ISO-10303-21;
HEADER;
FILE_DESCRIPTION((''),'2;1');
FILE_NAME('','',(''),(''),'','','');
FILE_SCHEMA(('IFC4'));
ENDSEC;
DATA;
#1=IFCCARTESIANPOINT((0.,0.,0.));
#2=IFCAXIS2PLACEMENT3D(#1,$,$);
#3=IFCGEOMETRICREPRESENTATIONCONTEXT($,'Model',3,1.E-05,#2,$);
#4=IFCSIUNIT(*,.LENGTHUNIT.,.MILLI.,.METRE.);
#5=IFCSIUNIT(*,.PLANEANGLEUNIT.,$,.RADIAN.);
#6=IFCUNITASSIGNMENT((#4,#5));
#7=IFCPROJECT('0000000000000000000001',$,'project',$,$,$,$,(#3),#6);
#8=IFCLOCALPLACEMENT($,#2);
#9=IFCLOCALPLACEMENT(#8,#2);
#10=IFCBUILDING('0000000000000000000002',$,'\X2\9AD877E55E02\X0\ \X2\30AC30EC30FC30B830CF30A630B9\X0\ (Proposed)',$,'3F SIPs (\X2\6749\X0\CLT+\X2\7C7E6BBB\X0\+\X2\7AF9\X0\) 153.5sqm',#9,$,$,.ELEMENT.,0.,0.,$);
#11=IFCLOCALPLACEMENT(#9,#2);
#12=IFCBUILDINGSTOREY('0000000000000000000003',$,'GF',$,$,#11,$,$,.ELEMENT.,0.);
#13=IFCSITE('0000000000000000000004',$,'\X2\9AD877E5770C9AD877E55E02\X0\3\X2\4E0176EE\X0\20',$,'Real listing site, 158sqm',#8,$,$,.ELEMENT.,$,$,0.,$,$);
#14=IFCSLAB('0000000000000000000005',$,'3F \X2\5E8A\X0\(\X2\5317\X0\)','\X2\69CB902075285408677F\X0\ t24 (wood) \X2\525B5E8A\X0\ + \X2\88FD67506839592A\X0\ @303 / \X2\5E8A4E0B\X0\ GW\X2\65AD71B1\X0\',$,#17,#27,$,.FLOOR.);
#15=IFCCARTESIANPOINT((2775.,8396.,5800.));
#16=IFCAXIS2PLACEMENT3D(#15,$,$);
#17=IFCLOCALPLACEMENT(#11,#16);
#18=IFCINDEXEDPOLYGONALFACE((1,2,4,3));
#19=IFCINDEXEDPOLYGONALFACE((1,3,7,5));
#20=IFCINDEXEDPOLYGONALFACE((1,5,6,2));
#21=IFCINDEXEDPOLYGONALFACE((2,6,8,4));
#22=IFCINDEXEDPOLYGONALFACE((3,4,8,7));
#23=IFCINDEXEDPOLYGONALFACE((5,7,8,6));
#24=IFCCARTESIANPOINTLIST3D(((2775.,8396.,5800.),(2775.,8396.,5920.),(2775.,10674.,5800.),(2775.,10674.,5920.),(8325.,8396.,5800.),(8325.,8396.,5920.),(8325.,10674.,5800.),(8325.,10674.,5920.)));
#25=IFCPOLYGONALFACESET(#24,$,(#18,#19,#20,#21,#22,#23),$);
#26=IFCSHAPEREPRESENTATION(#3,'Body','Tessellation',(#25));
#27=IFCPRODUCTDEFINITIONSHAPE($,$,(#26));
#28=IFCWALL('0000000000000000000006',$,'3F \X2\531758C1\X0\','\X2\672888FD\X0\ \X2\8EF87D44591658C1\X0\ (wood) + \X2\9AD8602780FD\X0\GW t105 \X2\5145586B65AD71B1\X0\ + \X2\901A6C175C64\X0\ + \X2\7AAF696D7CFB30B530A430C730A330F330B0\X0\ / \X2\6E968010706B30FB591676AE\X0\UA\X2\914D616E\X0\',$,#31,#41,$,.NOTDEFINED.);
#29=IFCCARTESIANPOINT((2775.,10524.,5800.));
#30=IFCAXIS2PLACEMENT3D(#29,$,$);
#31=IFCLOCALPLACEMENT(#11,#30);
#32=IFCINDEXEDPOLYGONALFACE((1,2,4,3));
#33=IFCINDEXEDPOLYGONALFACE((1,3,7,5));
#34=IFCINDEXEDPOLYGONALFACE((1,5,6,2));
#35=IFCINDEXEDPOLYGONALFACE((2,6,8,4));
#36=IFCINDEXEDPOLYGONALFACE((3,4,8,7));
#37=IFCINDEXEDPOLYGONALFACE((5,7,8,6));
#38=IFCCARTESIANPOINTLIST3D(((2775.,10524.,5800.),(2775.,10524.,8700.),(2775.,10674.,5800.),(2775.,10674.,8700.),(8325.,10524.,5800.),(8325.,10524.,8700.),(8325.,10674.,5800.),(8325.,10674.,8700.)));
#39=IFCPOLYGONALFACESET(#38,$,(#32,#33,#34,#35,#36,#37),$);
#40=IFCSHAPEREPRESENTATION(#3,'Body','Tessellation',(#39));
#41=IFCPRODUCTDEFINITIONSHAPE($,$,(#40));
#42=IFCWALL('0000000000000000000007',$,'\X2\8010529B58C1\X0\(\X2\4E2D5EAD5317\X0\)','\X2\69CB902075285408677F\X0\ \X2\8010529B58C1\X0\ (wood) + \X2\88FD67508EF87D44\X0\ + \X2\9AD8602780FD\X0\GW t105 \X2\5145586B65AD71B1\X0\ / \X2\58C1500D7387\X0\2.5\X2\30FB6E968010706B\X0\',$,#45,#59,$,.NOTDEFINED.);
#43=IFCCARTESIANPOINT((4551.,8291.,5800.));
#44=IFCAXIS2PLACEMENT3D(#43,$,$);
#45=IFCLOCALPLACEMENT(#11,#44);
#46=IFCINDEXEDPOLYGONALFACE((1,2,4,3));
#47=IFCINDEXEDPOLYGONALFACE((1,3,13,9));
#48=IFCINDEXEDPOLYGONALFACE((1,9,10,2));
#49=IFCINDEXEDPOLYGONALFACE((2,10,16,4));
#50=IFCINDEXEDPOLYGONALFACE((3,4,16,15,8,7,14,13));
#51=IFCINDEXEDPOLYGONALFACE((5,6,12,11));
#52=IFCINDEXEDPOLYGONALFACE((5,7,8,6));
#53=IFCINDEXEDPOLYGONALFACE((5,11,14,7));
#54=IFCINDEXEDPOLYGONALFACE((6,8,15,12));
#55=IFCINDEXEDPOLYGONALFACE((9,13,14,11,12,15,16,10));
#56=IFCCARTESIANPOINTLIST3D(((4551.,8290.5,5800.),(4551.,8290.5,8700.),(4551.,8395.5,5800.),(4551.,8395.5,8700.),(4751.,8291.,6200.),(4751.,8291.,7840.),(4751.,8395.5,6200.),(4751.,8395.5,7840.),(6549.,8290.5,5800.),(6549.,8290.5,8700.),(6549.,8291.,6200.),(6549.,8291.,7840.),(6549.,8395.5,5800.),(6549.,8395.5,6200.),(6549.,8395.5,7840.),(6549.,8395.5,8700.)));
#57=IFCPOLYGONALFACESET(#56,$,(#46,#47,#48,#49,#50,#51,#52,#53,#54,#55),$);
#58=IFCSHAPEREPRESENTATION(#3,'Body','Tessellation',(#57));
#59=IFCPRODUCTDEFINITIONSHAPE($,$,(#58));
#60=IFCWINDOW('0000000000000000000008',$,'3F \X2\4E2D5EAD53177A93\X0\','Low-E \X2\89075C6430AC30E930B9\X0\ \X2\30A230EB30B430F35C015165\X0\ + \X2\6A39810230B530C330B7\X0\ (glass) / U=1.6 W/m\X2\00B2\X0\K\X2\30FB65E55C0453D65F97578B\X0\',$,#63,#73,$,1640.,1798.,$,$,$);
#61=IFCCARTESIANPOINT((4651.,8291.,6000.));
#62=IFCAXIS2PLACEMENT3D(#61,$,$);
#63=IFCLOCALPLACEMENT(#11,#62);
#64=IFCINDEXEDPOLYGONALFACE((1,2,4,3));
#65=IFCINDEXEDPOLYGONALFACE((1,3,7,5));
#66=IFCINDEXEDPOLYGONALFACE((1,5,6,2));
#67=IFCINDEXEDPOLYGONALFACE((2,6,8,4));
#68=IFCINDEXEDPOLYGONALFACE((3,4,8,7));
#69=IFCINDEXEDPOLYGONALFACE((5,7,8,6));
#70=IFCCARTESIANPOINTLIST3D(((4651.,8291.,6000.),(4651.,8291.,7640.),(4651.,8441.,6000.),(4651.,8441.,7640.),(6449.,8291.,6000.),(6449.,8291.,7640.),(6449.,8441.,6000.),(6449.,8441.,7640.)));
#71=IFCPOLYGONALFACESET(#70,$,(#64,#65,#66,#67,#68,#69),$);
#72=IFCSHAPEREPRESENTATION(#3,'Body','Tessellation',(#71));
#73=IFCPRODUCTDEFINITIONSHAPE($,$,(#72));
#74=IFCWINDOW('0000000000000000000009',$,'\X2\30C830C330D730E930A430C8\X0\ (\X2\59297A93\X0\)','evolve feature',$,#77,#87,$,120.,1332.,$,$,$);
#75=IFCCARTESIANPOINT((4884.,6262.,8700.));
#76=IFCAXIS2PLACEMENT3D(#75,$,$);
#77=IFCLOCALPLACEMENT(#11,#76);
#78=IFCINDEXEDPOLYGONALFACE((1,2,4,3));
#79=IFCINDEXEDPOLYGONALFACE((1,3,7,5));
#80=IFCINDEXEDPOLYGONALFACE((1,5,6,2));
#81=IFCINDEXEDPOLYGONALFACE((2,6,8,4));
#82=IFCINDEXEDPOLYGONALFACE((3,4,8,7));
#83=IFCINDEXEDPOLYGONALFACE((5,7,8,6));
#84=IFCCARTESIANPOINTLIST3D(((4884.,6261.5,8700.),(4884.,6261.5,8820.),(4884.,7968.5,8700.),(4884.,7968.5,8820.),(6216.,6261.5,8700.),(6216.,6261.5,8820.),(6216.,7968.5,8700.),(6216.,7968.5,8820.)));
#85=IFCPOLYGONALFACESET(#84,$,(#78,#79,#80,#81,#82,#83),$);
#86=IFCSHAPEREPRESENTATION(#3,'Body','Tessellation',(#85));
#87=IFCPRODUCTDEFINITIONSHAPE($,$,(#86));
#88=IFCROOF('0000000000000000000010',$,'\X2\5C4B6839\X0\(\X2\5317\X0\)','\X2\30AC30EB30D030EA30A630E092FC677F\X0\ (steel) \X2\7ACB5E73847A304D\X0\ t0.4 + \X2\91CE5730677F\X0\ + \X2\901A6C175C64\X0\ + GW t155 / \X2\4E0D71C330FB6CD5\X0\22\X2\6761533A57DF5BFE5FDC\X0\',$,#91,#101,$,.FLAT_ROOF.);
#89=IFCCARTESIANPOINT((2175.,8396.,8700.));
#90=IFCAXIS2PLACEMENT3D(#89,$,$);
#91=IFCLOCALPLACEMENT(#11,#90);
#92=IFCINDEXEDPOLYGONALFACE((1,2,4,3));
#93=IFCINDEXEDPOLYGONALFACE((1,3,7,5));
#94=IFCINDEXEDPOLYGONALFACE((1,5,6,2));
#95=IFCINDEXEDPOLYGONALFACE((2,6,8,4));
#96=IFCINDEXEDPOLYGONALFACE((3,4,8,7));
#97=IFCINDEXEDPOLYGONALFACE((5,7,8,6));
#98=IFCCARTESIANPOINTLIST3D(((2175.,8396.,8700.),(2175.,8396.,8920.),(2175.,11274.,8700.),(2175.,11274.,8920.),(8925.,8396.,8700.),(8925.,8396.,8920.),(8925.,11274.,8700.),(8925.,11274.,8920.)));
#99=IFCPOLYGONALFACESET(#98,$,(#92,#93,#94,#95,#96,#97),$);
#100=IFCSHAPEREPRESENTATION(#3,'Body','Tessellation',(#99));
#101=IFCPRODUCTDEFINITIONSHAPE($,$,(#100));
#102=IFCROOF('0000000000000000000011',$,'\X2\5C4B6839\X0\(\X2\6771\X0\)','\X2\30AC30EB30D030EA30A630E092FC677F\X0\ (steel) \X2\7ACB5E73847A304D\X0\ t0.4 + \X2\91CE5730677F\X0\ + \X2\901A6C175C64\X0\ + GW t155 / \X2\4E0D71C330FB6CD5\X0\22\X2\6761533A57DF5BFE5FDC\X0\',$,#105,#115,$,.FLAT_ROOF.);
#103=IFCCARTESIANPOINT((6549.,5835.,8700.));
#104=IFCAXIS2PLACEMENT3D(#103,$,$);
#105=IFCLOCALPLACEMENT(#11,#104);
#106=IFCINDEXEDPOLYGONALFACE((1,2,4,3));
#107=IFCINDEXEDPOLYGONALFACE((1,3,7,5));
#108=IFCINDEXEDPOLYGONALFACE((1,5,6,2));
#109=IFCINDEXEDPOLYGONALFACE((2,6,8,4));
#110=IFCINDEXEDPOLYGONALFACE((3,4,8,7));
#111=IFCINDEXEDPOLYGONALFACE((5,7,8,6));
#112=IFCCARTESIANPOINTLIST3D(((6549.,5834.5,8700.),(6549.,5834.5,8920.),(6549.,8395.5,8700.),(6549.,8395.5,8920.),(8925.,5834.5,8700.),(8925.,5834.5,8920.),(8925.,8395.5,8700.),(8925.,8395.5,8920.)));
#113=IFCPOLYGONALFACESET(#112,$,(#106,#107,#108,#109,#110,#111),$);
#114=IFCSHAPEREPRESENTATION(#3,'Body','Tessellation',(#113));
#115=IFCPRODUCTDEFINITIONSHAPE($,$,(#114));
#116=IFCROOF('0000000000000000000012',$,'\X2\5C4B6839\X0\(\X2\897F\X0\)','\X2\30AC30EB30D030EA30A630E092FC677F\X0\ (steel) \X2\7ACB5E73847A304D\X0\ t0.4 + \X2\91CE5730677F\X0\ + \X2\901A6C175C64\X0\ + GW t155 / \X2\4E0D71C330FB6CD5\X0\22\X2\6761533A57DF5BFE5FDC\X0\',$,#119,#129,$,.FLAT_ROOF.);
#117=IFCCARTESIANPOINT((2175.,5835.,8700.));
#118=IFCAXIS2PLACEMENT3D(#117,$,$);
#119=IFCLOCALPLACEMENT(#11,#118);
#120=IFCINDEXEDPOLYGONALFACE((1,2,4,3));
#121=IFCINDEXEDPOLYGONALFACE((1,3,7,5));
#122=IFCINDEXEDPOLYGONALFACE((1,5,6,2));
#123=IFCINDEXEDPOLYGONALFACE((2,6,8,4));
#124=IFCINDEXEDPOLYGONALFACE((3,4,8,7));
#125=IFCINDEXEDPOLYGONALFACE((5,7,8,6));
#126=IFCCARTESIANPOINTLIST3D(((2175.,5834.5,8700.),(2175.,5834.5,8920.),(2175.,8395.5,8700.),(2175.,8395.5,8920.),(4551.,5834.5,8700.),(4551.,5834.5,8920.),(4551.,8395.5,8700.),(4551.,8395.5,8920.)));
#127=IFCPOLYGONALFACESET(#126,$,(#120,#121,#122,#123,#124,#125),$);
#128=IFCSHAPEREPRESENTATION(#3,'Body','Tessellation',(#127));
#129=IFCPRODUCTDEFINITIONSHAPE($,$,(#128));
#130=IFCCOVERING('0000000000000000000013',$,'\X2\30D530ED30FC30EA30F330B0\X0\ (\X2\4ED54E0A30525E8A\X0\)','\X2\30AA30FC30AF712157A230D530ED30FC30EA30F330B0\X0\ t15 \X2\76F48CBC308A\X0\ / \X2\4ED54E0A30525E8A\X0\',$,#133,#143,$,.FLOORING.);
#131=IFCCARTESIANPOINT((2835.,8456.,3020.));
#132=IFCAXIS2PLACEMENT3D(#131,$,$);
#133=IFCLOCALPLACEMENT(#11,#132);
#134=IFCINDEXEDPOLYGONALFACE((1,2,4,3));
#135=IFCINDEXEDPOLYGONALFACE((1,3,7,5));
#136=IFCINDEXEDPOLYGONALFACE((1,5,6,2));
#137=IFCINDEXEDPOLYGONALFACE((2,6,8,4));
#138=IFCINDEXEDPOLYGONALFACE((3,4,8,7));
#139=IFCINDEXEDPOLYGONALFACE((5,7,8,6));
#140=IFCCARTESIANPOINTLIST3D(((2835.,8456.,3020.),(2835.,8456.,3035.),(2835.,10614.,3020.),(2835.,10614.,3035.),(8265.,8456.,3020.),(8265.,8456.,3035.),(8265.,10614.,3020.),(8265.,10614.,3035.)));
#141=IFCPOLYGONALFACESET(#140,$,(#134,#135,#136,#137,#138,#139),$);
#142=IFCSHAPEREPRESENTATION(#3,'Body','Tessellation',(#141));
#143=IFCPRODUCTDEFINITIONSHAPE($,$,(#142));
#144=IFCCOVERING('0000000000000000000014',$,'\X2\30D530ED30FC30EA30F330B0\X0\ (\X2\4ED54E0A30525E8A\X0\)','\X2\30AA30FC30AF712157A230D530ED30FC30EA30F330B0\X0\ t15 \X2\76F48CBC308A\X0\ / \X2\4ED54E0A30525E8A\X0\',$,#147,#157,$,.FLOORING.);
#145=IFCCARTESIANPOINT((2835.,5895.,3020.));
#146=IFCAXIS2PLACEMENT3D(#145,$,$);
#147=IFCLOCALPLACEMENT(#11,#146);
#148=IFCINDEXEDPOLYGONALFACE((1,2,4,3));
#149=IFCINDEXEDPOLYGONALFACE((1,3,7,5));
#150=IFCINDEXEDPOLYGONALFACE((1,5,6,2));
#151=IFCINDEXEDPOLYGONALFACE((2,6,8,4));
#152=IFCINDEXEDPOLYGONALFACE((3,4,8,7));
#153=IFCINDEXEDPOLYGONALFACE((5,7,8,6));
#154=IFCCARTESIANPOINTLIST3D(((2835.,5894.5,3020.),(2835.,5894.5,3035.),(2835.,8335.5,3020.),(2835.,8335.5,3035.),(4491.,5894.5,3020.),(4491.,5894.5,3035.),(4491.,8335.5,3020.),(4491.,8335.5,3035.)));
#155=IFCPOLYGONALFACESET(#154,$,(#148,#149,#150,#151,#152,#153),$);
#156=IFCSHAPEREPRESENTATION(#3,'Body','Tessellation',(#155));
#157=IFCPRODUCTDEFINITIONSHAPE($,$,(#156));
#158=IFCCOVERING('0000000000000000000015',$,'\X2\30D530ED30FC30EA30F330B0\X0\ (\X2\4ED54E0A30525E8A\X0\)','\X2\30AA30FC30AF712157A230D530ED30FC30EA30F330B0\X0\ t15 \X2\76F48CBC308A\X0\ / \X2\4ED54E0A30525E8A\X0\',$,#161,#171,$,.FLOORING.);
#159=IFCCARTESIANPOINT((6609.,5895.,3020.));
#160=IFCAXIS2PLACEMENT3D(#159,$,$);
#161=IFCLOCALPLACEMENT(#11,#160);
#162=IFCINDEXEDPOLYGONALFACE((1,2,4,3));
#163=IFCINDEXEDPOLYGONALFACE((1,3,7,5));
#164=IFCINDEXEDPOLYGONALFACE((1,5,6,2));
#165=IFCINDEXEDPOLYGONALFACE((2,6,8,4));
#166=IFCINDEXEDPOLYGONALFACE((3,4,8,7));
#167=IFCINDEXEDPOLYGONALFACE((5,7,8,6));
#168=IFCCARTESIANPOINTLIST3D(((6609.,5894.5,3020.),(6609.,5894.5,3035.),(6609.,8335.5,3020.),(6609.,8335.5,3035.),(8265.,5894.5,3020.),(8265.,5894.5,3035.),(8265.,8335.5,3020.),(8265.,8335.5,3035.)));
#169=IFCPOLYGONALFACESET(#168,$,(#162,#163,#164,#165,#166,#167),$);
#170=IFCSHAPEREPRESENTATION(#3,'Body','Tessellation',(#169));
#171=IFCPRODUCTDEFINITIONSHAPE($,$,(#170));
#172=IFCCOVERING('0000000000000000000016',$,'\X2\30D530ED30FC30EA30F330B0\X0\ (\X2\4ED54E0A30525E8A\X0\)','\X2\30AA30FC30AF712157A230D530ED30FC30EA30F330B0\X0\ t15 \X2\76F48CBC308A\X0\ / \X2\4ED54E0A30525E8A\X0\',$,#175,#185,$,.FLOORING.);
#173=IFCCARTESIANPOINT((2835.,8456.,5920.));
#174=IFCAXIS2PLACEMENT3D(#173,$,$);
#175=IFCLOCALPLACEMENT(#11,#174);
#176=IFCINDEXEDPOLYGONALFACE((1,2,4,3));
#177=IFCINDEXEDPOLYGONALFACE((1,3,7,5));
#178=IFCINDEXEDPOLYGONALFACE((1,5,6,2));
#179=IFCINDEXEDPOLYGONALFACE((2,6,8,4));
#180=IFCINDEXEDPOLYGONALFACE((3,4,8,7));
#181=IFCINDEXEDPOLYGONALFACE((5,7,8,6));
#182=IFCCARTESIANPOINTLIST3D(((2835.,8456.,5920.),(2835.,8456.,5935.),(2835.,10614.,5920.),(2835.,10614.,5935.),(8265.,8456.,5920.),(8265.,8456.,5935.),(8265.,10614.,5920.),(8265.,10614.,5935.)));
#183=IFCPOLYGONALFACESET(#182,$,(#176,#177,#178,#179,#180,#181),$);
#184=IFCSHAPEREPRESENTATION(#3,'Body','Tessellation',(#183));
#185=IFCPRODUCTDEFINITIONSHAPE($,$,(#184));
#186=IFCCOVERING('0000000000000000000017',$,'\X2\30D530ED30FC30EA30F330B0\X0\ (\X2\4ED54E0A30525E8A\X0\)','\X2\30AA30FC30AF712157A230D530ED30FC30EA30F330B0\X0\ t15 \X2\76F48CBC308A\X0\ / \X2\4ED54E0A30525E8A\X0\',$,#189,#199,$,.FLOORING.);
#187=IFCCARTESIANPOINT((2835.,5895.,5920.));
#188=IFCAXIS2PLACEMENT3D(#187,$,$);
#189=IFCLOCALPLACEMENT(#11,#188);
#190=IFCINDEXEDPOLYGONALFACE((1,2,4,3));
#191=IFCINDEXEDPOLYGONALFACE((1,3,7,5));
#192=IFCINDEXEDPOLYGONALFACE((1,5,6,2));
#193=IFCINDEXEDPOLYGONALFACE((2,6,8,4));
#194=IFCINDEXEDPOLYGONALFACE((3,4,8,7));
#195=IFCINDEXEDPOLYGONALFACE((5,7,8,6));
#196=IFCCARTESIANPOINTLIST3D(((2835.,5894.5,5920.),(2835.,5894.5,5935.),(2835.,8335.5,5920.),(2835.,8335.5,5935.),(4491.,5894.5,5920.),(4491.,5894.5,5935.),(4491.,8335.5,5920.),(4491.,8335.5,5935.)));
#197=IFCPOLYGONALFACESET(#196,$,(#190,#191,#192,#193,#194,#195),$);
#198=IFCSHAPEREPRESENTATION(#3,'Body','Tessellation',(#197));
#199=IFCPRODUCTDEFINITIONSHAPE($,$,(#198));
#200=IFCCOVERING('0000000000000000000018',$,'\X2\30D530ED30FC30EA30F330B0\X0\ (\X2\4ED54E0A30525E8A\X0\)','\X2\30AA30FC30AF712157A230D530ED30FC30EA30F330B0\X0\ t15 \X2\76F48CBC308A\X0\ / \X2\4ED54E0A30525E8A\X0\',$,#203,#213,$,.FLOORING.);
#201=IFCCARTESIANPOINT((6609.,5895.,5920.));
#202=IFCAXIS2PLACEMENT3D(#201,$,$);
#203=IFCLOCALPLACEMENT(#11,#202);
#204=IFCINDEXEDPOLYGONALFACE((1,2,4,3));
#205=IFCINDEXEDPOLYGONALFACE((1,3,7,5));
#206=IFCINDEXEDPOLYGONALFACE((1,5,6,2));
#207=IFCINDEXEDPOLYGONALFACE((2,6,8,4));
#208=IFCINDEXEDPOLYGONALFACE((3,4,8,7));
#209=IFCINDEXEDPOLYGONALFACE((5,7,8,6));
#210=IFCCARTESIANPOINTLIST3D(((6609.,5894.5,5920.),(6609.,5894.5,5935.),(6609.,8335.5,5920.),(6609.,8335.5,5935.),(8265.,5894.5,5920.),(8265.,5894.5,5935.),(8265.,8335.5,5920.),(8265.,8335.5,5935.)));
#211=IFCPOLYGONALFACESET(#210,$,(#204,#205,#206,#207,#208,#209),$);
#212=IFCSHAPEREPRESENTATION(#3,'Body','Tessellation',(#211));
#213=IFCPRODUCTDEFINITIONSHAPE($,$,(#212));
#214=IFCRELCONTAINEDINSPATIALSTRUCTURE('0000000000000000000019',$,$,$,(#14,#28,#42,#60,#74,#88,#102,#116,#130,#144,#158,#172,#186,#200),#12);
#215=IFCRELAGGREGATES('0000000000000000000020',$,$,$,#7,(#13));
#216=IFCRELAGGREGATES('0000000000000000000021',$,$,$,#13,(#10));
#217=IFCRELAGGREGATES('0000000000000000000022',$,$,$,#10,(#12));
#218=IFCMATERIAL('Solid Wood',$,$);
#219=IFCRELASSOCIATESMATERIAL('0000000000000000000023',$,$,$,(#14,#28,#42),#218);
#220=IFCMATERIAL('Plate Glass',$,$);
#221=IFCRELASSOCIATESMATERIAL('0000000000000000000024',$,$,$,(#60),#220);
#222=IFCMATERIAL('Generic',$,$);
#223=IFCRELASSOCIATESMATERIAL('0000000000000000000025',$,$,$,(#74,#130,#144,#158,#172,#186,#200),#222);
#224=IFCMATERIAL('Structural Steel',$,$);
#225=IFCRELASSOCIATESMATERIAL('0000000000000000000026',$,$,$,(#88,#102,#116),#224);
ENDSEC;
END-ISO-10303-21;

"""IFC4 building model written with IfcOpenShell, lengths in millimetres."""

from ifc_helpers import new_model, si_unit, frame, frame_2d, origin, place, context, project, spatial, rectangle, extrude, material, element, fill, save


model = new_model("IFC4")

# Units and contexts
model_context = context("Model", 3, precision=1e-05, world=origin())
ifc_project = project(units=[si_unit("LENGTHUNIT", "METRE", prefix="MILLI"), si_unit("PLANEANGLEUNIT", "RADIAN")], contexts=[model_context])

# Site, building, storey
site_placement = place(None, origin())
site = spatial("IfcSite", under=ifc_project, at=site_placement, Name="高知県高知市3丁目20", ObjectType="Real listing site, 158sqm", CompositionType="ELEMENT", RefElevation=0.0)
building_placement = place(site_placement, origin())
building = spatial("IfcBuilding", under=site, at=building_placement, Name="高知市 ガレージハウス (Proposed)", ObjectType="3F SIPs (杉CLT+籾殻+竹) 153.5sqm", CompositionType="ELEMENT", ElevationOfRefHeight=0.0, ElevationOfTerrain=0.0)
storey_placement = place(building_placement, origin())
storey = spatial("IfcBuildingStorey", under=building, at=storey_placement, Name="GF", CompositionType="ELEMENT", Elevation=0.0)

# Slab
ifc_material_1 = material(Name="Solid Wood")
slab_placement = place(storey_placement, frame((2775.0, 8396.0, 5800.0)))
element("IfcSlab", 1, at=slab_placement, inside=storey, material=ifc_material_1, Name="3F 床(北)", Description="構造用合板 t24 (wood) 剛床 + 製材根太 @303 / 床下 GW断熱", PredefinedType="FLOOR", context=model_context, shape_type="SweptSolid", body=[
    extrude(rectangle(XDim=5550.0, YDim=2278.0, at=frame_2d((2775.0, 1139.0))), frame((2775.0, 8396.0, 5800.0)), (0.0, 0.0, 1.0), 120.0),
])

# Wall
wall_1_placement = place(storey_placement, frame((2775.0, 10524.0, 5800.0)))
element("IfcWall", 2, at=wall_1_placement, inside=storey, material=ifc_material_1, Name="3F 北壁", Description="木製 軸組外壁 (wood) + 高性能GW t105 充填断熱 + 通気層 + 窯業系サイディング / 準耐火・外皮UA配慮", PredefinedType="NOTDEFINED", context=model_context, shape_type="SweptSolid", body=[
    extrude(rectangle(XDim=5550.0, YDim=150.0, at=frame_2d((2775.0, 75.0))), frame((2775.0, 10524.0, 5800.0)), (0.0, 0.0, 1.0), 2900.0),
])

# Wall, opening, window
wall_2_placement = place(storey_placement, frame((4551.0, 8291.0, 5800.0)))
wall_2 = element("IfcWall", 3, at=wall_2_placement, inside=storey, material=ifc_material_1, Name="耐力壁(中庭北)", Description="構造用合板 耐力壁 (wood) + 製材軸組 + 高性能GW t105 充填断熱 / 壁倍率2.5・準耐火", PredefinedType="NOTDEFINED", context=model_context, shape_type="SweptSolid", body=[
    extrude(rectangle(XDim=1998.0, YDim=105.0, at=frame_2d((999.0, 52.0))), frame((4551.0, 8291.0, 5800.0)), (0.0, 0.0, 1.0), 2900.0),
])
opening_placement = place(storey_placement, frame((4651.0, 8291.0, 6000.0)))
opening = element("IfcOpeningElement", 4, at=opening_placement, cuts=wall_2, PredefinedType="NOTDEFINED", context=model_context, shape_type="SweptSolid", body=[
    extrude(rectangle(XDim=1798.0, YDim=150.0, at=frame_2d((899.0, 75.0))), frame((4651.0, 8291.0, 6000.0)), (0.0, 0.0, 1.0), 1640.0),
])
ifc_material_2 = material(Name="Plate Glass")
window_1_placement = place(storey_placement, frame((4651.0, 8291.0, 6000.0)))
window_1 = element("IfcWindow", 5, at=window_1_placement, inside=storey, material=ifc_material_2, Name="3F 中庭北窓", Description="Low-E 複層ガラス アルゴン封入 + 樹脂サッシ (glass) / U=1.6 W/m²K・日射取得型", OverallHeight=1640.0, OverallWidth=1798.0, context=model_context, shape_type="SweptSolid", body=[
    extrude(rectangle(XDim=1798.0, YDim=150.0, at=frame_2d((899.0, 75.0))), frame((4651.0, 8291.0, 6000.0)), (0.0, 0.0, 1.0), 1640.0),
])
fill(opening, window_1)

# Window
ifc_material_3 = material(Name="Generic")
window_2_placement = place(storey_placement, frame((4884.0, 6262.0, 8700.0)))
element("IfcWindow", 6, at=window_2_placement, inside=storey, material=ifc_material_3, Name="トップライト (天窓)", Description="evolve feature", OverallHeight=120.0, OverallWidth=1332.0, context=model_context, shape_type="SweptSolid", body=[
    extrude(rectangle(XDim=1332.0, YDim=1707.0, at=frame_2d((666.0, 853.0))), frame((4884.0, 6262.0, 8700.0)), (0.0, 0.0, 1.0), 120.0),
])

# Roofs
ifc_material_4 = material(Name="Structural Steel")
roof_1_placement = place(storey_placement, frame((2175.0, 8396.0, 8700.0)))
element("IfcRoof", 7, at=roof_1_placement, inside=storey, material=ifc_material_4, Name="屋根(北)", Description="ガルバリウム鋼板 (steel) 立平葺き t0.4 + 野地板 + 通気層 + GW t155 / 不燃・法22条区域対応", PredefinedType="FLAT_ROOF", context=model_context, shape_type="SweptSolid", body=[
    extrude(rectangle(XDim=6750.0, YDim=2878.0, at=frame_2d((3375.0, 1439.0))), frame((2175.0, 8396.0, 8700.0)), (0.0, 0.0, 1.0), 220.0),
])
roof_2_placement = place(storey_placement, frame((6549.0, 5835.0, 8700.0)))
element("IfcRoof", 8, at=roof_2_placement, inside=storey, material=ifc_material_4, Name="屋根(東)", Description="ガルバリウム鋼板 (steel) 立平葺き t0.4 + 野地板 + 通気層 + GW t155 / 不燃・法22条区域対応", PredefinedType="FLAT_ROOF", context=model_context, shape_type="SweptSolid", body=[
    extrude(rectangle(XDim=2376.0, YDim=2561.0, at=frame_2d((1188.0, 1280.0))), frame((6549.0, 5835.0, 8700.0)), (0.0, 0.0, 1.0), 220.0),
])
roof_3_placement = place(storey_placement, frame((2175.0, 5835.0, 8700.0)))
element("IfcRoof", 9, at=roof_3_placement, inside=storey, material=ifc_material_4, Name="屋根(西)", Description="ガルバリウム鋼板 (steel) 立平葺き t0.4 + 野地板 + 通気層 + GW t155 / 不燃・法22条区域対応", PredefinedType="FLAT_ROOF", context=model_context, shape_type="SweptSolid", body=[
    extrude(rectangle(XDim=2376.0, YDim=2561.0, at=frame_2d((1188.0, 1280.0))), frame((2175.0, 5835.0, 8700.0)), (0.0, 0.0, 1.0), 220.0),
])

# Coverings
covering_1_placement = place(storey_placement, frame((2835.0, 8456.0, 3020.0)))
element("IfcCovering", 10, at=covering_1_placement, inside=storey, material=ifc_material_3, Name="フローリング (仕上げ床)", Description="オーク無垢フローリング t15 直貼り / 仕上げ床", PredefinedType="FLOORING", context=model_context, shape_type="SweptSolid", body=[
    extrude(rectangle(XDim=5430.0, YDim=2158.0, at=frame_2d((2715.0, 1079.0))), frame((2835.0, 8456.0, 3020.0)), (0.0, 0.0, 1.0), 15.0),
])
covering_2_placement = place(storey_placement, frame((2835.0, 5895.0, 3020.0)))
element("IfcCovering", 11, at=covering_2_placement, inside=storey, material=ifc_material_3, Name="フローリング (仕上げ床)", Description="オーク無垢フローリング t15 直貼り / 仕上げ床", PredefinedType="FLOORING", context=model_context, shape_type="SweptSolid", body=[
    extrude(rectangle(XDim=1656.0, YDim=2441.0, at=frame_2d((828.0, 1220.0))), frame((2835.0, 5895.0, 3020.0)), (0.0, 0.0, 1.0), 15.0),
])
covering_3_placement = place(storey_placement, frame((6609.0, 5895.0, 3020.0)))
element("IfcCovering", 12, at=covering_3_placement, inside=storey, material=ifc_material_3, Name="フローリング (仕上げ床)", Description="オーク無垢フローリング t15 直貼り / 仕上げ床", PredefinedType="FLOORING", context=model_context, shape_type="SweptSolid", body=[
    extrude(rectangle(XDim=1656.0, YDim=2441.0, at=frame_2d((828.0, 1220.0))), frame((6609.0, 5895.0, 3020.0)), (0.0, 0.0, 1.0), 15.0),
])
covering_4_placement = place(storey_placement, frame((2835.0, 8456.0, 5920.0)))
element("IfcCovering", 13, at=covering_4_placement, inside=storey, material=ifc_material_3, Name="フローリング (仕上げ床)", Description="オーク無垢フローリング t15 直貼り / 仕上げ床", PredefinedType="FLOORING", context=model_context, shape_type="SweptSolid", body=[
    extrude(rectangle(XDim=5430.0, YDim=2158.0, at=frame_2d((2715.0, 1079.0))), frame((2835.0, 8456.0, 5920.0)), (0.0, 0.0, 1.0), 15.0),
])
covering_5_placement = place(storey_placement, frame((2835.0, 5895.0, 5920.0)))
element("IfcCovering", 14, at=covering_5_placement, inside=storey, material=ifc_material_3, Name="フローリング (仕上げ床)", Description="オーク無垢フローリング t15 直貼り / 仕上げ床", PredefinedType="FLOORING", context=model_context, shape_type="SweptSolid", body=[
    extrude(rectangle(XDim=1656.0, YDim=2441.0, at=frame_2d((828.0, 1220.0))), frame((2835.0, 5895.0, 5920.0)), (0.0, 0.0, 1.0), 15.0),
])
covering_6_placement = place(storey_placement, frame((6609.0, 5895.0, 5920.0)))
element("IfcCovering", 15, at=covering_6_placement, inside=storey, material=ifc_material_3, Name="フローリング (仕上げ床)", Description="オーク無垢フローリング t15 直貼り / 仕上げ床", PredefinedType="FLOORING", context=model_context, shape_type="SweptSolid", body=[
    extrude(rectangle(XDim=1656.0, YDim=2441.0, at=frame_2d((828.0, 1220.0))), frame((6609.0, 5895.0, 5920.0)), (0.0, 0.0, 1.0), 15.0),
])

save(model, "model.ifc")
